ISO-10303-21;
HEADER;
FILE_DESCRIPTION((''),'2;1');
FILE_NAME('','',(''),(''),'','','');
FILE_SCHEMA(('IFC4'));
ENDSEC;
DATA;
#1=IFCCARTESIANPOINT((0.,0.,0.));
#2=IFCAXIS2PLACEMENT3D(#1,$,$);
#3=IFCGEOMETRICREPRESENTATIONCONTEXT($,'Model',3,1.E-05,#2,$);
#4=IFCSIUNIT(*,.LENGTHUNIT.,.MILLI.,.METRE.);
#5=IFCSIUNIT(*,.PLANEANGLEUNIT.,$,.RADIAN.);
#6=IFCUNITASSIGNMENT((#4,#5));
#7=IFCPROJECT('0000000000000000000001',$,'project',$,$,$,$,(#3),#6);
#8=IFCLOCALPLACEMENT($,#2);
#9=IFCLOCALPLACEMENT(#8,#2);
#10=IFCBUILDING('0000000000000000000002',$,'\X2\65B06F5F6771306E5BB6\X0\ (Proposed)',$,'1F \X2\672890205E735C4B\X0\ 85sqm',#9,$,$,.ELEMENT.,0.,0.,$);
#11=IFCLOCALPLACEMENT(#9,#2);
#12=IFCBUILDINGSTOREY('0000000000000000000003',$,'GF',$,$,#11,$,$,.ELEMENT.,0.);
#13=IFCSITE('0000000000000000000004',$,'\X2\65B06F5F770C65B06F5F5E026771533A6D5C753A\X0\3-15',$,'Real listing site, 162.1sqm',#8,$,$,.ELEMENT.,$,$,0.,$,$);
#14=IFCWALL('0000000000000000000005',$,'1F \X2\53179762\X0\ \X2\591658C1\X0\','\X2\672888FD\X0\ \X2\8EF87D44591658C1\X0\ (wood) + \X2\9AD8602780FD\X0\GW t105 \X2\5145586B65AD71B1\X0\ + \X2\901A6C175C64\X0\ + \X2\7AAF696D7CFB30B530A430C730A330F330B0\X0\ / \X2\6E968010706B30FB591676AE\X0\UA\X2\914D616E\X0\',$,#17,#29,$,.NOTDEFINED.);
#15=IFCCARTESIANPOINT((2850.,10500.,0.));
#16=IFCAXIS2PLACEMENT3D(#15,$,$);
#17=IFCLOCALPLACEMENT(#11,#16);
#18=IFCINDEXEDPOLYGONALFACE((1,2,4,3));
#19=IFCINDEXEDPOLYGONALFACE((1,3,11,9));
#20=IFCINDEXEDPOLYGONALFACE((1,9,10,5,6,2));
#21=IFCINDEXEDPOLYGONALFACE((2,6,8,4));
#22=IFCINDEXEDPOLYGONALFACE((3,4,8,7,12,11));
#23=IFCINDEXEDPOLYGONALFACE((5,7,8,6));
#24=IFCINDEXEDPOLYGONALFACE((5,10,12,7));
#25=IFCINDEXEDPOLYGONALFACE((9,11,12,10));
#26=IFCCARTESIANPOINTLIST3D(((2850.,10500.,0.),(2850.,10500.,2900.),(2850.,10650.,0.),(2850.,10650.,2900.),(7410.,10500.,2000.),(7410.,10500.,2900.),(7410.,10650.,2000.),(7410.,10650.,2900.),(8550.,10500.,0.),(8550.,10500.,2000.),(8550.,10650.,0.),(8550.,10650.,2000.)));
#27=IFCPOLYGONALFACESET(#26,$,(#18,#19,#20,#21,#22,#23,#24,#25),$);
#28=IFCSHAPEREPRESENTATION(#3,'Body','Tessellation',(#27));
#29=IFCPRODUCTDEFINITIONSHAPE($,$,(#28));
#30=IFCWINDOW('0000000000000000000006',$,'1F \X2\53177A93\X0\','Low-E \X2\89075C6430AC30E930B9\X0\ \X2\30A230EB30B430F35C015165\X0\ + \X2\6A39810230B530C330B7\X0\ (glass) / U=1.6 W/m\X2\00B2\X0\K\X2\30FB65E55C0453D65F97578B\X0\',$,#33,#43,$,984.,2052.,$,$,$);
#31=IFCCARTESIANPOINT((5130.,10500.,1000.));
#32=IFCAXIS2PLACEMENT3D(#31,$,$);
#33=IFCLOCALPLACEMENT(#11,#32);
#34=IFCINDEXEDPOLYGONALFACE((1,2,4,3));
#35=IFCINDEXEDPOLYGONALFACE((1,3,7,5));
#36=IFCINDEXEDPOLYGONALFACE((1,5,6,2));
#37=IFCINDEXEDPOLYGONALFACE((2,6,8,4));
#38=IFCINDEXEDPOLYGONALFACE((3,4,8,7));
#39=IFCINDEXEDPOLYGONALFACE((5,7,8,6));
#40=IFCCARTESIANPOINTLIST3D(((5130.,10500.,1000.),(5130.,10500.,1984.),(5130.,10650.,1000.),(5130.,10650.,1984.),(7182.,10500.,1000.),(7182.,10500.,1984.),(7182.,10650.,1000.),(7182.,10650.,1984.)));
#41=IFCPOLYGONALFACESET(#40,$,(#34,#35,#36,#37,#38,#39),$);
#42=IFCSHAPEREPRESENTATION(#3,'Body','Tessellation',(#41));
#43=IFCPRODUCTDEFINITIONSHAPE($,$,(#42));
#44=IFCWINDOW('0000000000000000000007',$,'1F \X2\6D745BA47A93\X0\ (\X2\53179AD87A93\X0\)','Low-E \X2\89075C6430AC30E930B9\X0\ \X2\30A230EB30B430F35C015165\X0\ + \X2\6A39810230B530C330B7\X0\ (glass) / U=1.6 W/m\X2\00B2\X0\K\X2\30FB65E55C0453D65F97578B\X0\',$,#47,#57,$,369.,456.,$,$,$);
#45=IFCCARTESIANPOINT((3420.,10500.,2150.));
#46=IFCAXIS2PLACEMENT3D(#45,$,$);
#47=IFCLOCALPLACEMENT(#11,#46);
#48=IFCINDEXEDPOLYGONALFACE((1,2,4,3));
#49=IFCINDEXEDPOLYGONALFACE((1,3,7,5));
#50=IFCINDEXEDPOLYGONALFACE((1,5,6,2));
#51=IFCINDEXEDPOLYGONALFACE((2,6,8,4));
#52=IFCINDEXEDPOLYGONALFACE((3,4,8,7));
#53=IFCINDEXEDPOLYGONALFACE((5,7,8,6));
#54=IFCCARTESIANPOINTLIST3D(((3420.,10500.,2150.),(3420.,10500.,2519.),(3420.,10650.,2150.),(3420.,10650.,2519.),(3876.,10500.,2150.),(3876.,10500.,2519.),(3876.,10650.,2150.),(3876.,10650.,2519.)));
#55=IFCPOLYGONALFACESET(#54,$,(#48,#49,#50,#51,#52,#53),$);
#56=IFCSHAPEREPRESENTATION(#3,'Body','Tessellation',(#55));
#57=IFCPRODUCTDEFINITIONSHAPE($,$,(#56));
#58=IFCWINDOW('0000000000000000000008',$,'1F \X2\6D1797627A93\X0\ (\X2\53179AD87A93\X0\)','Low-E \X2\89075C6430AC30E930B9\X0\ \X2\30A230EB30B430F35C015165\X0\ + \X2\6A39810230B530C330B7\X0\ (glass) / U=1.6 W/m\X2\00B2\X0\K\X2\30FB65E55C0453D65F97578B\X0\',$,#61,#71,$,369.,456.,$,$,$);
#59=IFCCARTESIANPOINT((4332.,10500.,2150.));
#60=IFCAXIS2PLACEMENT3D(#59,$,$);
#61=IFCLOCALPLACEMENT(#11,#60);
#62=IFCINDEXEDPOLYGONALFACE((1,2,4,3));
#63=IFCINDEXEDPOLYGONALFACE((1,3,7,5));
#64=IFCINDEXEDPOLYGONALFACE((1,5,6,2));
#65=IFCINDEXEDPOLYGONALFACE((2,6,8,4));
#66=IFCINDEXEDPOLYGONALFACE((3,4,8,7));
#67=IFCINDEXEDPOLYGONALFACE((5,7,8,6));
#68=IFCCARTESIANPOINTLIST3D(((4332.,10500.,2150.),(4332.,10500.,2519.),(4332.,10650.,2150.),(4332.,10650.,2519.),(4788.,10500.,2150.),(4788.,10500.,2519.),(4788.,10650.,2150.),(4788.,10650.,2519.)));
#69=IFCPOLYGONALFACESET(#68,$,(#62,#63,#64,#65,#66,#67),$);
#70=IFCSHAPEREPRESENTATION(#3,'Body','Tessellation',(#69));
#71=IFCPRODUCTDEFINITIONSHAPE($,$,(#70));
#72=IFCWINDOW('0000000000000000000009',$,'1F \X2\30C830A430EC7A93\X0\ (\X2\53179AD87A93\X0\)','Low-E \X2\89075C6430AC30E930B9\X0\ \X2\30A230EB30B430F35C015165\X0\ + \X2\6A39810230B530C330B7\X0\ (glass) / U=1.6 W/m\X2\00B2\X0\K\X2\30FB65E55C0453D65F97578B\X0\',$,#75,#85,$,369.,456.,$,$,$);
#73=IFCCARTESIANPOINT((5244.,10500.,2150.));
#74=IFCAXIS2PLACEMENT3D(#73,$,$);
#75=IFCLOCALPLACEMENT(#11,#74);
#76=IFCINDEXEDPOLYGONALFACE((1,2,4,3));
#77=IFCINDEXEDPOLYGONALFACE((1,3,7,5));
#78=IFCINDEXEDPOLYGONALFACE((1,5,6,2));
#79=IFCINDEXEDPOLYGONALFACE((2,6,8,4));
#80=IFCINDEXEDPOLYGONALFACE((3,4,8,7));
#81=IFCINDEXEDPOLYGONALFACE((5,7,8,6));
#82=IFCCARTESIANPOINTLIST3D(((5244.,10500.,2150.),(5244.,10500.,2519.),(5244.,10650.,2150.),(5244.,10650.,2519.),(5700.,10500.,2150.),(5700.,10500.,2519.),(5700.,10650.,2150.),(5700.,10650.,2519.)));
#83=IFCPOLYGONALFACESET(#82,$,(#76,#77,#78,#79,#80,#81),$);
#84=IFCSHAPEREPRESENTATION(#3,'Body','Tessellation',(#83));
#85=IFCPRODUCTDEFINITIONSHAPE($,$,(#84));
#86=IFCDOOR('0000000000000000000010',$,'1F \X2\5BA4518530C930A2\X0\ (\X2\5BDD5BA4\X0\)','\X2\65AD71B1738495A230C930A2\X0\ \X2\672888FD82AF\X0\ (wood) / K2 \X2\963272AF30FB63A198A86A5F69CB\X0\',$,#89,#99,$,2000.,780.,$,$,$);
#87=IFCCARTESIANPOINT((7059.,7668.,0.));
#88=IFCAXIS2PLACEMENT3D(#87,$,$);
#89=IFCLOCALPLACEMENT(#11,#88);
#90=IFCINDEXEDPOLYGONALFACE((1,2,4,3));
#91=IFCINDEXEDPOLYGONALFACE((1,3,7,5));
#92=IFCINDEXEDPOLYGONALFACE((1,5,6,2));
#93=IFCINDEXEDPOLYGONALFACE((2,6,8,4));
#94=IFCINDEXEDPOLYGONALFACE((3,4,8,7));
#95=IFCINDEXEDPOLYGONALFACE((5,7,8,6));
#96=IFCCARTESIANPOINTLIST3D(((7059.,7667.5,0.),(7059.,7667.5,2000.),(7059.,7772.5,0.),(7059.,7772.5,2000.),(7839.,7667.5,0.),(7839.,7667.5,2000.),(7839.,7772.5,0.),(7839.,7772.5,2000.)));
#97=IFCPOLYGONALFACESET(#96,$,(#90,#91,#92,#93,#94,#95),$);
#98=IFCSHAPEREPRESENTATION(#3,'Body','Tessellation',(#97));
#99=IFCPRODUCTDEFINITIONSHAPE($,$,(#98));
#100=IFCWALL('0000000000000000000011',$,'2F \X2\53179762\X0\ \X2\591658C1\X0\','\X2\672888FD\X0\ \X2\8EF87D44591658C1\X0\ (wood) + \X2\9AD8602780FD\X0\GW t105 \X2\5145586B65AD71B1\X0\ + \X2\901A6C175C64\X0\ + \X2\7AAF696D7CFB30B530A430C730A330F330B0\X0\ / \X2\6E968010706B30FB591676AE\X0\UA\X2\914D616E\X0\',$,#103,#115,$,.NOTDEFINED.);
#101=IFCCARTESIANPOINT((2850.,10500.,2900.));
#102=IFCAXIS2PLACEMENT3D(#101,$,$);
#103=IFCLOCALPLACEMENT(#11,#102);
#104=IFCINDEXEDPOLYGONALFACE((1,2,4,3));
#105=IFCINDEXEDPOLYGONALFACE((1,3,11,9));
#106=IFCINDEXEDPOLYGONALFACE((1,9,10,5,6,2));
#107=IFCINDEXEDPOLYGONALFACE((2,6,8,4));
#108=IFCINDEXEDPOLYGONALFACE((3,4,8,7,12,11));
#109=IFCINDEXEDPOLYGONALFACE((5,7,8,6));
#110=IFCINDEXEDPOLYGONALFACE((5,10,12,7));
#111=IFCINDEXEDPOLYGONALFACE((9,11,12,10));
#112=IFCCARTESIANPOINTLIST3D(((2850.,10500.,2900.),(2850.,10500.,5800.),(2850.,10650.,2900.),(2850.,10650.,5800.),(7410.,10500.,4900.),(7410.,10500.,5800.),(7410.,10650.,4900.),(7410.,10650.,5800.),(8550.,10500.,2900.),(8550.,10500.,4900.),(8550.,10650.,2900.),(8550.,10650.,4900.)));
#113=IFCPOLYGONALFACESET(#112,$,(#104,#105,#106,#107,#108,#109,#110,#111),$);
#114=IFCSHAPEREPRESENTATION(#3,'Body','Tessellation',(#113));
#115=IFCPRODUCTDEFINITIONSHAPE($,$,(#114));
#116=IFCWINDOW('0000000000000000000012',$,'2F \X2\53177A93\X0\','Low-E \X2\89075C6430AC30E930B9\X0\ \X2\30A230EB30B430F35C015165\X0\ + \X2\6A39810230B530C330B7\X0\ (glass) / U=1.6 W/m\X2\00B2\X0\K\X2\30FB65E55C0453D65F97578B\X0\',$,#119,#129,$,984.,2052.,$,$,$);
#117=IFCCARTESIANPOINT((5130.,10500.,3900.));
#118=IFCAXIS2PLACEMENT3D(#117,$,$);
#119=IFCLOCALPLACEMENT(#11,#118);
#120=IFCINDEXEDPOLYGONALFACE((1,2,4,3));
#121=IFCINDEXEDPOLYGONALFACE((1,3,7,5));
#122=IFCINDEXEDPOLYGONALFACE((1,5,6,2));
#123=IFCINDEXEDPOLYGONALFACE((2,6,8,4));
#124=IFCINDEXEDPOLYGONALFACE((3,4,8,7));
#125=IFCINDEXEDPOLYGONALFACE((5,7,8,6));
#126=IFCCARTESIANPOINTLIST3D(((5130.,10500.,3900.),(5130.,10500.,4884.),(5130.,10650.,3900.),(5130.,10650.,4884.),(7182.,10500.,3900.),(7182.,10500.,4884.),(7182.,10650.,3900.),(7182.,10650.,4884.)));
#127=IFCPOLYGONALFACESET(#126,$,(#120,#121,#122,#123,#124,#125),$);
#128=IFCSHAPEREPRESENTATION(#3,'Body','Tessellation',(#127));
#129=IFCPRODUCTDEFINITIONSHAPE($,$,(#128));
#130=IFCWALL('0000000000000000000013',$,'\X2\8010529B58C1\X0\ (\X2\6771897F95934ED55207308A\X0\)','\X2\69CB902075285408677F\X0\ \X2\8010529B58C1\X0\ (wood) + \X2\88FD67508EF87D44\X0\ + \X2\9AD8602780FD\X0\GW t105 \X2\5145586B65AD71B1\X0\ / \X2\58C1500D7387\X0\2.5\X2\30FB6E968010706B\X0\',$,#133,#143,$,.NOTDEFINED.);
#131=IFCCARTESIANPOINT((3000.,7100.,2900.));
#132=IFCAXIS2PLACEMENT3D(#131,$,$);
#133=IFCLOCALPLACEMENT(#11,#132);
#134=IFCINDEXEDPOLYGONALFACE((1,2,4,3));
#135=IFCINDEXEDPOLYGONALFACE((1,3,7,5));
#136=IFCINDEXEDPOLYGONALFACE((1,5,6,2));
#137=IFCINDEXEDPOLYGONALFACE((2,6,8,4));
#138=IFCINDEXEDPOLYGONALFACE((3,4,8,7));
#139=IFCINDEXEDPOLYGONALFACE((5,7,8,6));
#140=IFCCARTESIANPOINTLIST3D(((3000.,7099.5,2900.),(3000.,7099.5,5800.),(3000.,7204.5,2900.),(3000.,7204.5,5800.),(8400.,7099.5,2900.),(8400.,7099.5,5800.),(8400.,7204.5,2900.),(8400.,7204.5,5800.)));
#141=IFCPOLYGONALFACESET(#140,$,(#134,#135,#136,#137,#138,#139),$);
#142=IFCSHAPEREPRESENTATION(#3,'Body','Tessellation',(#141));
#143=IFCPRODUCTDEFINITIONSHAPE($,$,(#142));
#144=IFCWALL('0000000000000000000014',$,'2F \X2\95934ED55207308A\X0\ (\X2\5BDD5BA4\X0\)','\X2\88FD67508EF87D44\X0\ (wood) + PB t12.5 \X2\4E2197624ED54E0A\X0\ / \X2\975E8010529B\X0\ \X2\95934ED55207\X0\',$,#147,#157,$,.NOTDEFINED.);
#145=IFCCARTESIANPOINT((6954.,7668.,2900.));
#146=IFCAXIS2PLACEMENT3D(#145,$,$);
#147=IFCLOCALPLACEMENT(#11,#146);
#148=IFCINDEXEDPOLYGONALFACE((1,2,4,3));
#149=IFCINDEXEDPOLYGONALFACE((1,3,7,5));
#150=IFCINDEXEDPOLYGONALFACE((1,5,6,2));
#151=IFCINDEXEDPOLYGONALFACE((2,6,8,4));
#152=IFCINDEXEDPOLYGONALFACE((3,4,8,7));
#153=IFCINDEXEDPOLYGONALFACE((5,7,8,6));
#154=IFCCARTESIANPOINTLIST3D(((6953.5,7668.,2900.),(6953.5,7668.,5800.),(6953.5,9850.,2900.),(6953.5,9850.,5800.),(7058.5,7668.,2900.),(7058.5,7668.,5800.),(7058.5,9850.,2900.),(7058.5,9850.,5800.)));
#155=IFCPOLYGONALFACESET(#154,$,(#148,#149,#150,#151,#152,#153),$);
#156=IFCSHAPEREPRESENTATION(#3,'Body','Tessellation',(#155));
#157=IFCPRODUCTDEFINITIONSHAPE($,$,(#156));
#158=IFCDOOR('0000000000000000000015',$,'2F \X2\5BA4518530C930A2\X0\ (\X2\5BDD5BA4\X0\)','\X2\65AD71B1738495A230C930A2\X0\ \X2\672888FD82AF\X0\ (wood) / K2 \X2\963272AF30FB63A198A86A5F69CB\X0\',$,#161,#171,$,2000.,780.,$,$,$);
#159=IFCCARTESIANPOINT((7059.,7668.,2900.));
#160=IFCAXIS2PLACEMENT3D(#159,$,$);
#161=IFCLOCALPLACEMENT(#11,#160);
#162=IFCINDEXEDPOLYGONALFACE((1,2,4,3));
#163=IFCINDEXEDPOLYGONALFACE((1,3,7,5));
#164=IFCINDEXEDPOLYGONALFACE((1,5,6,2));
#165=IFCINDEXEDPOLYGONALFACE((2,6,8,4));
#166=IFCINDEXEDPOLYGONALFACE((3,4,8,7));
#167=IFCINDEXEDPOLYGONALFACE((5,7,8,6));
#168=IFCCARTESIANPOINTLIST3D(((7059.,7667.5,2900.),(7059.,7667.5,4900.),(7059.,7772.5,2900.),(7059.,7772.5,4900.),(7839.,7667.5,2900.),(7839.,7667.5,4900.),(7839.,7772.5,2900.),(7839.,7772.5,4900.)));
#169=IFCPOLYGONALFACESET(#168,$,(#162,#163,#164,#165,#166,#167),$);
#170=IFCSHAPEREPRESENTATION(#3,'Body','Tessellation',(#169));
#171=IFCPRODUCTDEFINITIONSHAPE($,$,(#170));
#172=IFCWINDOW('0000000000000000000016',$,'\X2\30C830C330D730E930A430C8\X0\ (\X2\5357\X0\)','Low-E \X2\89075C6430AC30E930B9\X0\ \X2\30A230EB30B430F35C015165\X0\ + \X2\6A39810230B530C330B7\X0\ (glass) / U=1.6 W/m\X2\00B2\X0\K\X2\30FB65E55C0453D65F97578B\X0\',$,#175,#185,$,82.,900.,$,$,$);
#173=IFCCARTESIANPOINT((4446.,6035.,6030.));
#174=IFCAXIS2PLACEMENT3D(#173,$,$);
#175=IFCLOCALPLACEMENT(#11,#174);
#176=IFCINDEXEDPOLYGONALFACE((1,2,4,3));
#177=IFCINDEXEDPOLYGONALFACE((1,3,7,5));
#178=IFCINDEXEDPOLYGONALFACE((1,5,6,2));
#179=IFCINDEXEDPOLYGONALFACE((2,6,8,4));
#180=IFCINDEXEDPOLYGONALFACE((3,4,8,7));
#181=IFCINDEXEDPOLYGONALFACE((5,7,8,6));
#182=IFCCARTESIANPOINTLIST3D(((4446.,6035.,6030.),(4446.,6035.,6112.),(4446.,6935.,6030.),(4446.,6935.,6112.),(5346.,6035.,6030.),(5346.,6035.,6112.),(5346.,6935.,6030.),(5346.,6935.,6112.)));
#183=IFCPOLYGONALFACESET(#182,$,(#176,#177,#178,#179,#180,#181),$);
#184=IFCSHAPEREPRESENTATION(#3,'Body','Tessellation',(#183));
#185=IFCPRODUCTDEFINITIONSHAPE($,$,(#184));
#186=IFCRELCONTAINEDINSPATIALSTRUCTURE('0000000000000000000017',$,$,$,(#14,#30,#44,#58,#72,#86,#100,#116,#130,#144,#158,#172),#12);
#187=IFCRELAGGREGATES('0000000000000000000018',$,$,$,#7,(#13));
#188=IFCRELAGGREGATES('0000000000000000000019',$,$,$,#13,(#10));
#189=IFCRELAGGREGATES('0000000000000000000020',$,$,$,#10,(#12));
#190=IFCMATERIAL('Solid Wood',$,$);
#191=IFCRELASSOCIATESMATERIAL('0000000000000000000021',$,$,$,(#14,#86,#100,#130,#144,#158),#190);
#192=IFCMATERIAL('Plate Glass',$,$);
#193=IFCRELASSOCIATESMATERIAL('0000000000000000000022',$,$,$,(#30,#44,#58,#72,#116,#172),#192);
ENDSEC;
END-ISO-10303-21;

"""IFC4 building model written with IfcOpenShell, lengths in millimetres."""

from ifc_helpers import new_model, si_unit, frame, frame_2d, origin, place, context, project, spatial, rectangle, extrude, material, element, fill, save


model = new_model("IFC4")

# Units and contexts
model_context = context("Model", 3, precision=1e-05, world=origin())
ifc_project = project(units=[si_unit("LENGTHUNIT", "METRE", prefix="MILLI"), si_unit("PLANEANGLEUNIT", "RADIAN")], contexts=[model_context])

# Site, building, storey
site_placement = place(None, origin())
site = spatial("IfcSite", under=ifc_project, at=site_placement, Name="新潟県新潟市東区浜町3-15", ObjectType="Real listing site, 162.1sqm", CompositionType="ELEMENT", RefElevation=0.0)
building_placement = place(site_placement, origin())
building = spatial("IfcBuilding", under=site, at=building_placement, Name="新潟東の家 (Proposed)", ObjectType="1F 木造平屋 85sqm", CompositionType="ELEMENT", ElevationOfRefHeight=0.0, ElevationOfTerrain=0.0)
storey_placement = place(building_placement, origin())
storey = spatial("IfcBuildingStorey", under=building, at=storey_placement, Name="GF", CompositionType="ELEMENT", Elevation=0.0)

# Wall, openings, windows
ifc_material_1 = material(Name="Solid Wood")
wall_1_placement = place(storey_placement, frame((2850.0, 10500.0, 0.0)))
wall_1 = element("IfcWall", 1, at=wall_1_placement, inside=storey, material=ifc_material_1, Name="1F 北面 外壁", Description="木製 軸組外壁 (wood) + 高性能GW t105 充填断熱 + 通気層 + 窯業系サイディング / 準耐火・外皮UA配慮", PredefinedType="NOTDEFINED", context=model_context, shape_type="SweptSolid", body=[
    extrude(rectangle(XDim=5700.0, YDim=150.0, at=frame_2d((2850.0, 75.0))), frame((2850.0, 10500.0, 0.0)), (0.0, 0.0, 1.0), 2900.0),
])
opening_1_placement = place(storey_placement, frame((5130.0, 10500.0, 1000.0)))
opening_1 = element("IfcOpeningElement", 2, at=opening_1_placement, cuts=wall_1, PredefinedType="NOTDEFINED", context=model_context, shape_type="SweptSolid", body=[
    extrude(rectangle(XDim=2052.0, YDim=150.0, at=frame_2d((1026.0, 75.0))), frame((5130.0, 10500.0, 1000.0)), (0.0, 0.0, 1.0), 984.0),
])
opening_2_placement = place(storey_placement, frame((3420.0, 10500.0, 2150.0)))
opening_2 = element("IfcOpeningElement", 3, at=opening_2_placement, cuts=wall_1, PredefinedType="NOTDEFINED", context=model_context, shape_type="SweptSolid", body=[
    extrude(rectangle(XDim=456.0, YDim=150.0, at=frame_2d((228.0, 75.0))), frame((3420.0, 10500.0, 2150.0)), (0.0, 0.0, 1.0), 369.0),
])
opening_3_placement = place(storey_placement, frame((4332.0, 10500.0, 2150.0)))
opening_3 = element("IfcOpeningElement", 4, at=opening_3_placement, cuts=wall_1, PredefinedType="NOTDEFINED", context=model_context, shape_type="SweptSolid", body=[
    extrude(rectangle(XDim=456.0, YDim=150.0, at=frame_2d((228.0, 75.0))), frame((4332.0, 10500.0, 2150.0)), (0.0, 0.0, 1.0), 369.0),
])
opening_4_placement = place(storey_placement, frame((5244.0, 10500.0, 2150.0)))
opening_4 = element("IfcOpeningElement", 5, at=opening_4_placement, cuts=wall_1, PredefinedType="NOTDEFINED", context=model_context, shape_type="SweptSolid", body=[
    extrude(rectangle(XDim=456.0, YDim=150.0, at=frame_2d((228.0, 75.0))), frame((5244.0, 10500.0, 2150.0)), (0.0, 0.0, 1.0), 369.0),
])
ifc_material_2 = material(Name="Plate Glass")
window_1_placement = place(storey_placement, frame((5130.0, 10500.0, 1000.0)))
window_1 = element("IfcWindow", 6, at=window_1_placement, inside=storey, material=ifc_material_2, Name="1F 北窓", Description="Low-E 複層ガラス アルゴン封入 + 樹脂サッシ (glass) / U=1.6 W/m²K・日射取得型", OverallHeight=984.0, OverallWidth=2052.0, context=model_context, shape_type="SweptSolid", body=[
    extrude(rectangle(XDim=2052.0, YDim=150.0, at=frame_2d((1026.0, 75.0))), frame((5130.0, 10500.0, 1000.0)), (0.0, 0.0, 1.0), 984.0),
])
fill(opening_1, window_1)
window_2_placement = place(storey_placement, frame((3420.0, 10500.0, 2150.0)))
window_2 = element("IfcWindow", 7, at=window_2_placement, inside=storey, material=ifc_material_2, Name="1F 浴室窓 (北高窓)", Description="Low-E 複層ガラス アルゴン封入 + 樹脂サッシ (glass) / U=1.6 W/m²K・日射取得型", OverallHeight=369.0, OverallWidth=456.0, context=model_context, shape_type="SweptSolid", body=[
    extrude(rectangle(XDim=456.0, YDim=150.0, at=frame_2d((228.0, 75.0))), frame((3420.0, 10500.0, 2150.0)), (0.0, 0.0, 1.0), 369.0),
])
fill(opening_2, window_2)
window_3_placement = place(storey_placement, frame((4332.0, 10500.0, 2150.0)))
window_3 = element("IfcWindow", 8, at=window_3_placement, inside=storey, material=ifc_material_2, Name="1F 洗面窓 (北高窓)", Description="Low-E 複層ガラス アルゴン封入 + 樹脂サッシ (glass) / U=1.6 W/m²K・日射取得型", OverallHeight=369.0, OverallWidth=456.0, context=model_context, shape_type="SweptSolid", body=[
    extrude(rectangle(XDim=456.0, YDim=150.0, at=frame_2d((228.0, 75.0))), frame((4332.0, 10500.0, 2150.0)), (0.0, 0.0, 1.0), 369.0),
])
fill(opening_3, window_3)
window_4_placement = place(storey_placement, frame((5244.0, 10500.0, 2150.0)))
window_4 = element("IfcWindow", 9, at=window_4_placement, inside=storey, material=ifc_material_2, Name="1F トイレ窓 (北高窓)", Description="Low-E 複層ガラス アルゴン封入 + 樹脂サッシ (glass) / U=1.6 W/m²K・日射取得型", OverallHeight=369.0, OverallWidth=456.0, context=model_context, shape_type="SweptSolid", body=[
    extrude(rectangle(XDim=456.0, YDim=150.0, at=frame_2d((228.0, 75.0))), frame((5244.0, 10500.0, 2150.0)), (0.0, 0.0, 1.0), 369.0),
])
fill(opening_4, window_4)

# Door
door_1_placement = place(storey_placement, frame((7059.0, 7668.0, 0.0)))
element("IfcDoor", 10, at=door_1_placement, inside=storey, material=ifc_material_1, Name="1F 室内ドア (寝室)", Description="断熱玄関ドア 木製芯 (wood) / K2 防犯・採風機構", OverallHeight=2000.0, OverallWidth=780.0, context=model_context, shape_type="SweptSolid", body=[
    extrude(rectangle(XDim=780.0, YDim=105.0, at=frame_2d((390.0, 52.0))), frame((7059.0, 7668.0, 0.0)), (0.0, 0.0, 1.0), 2000.0),
])

# Wall, opening, window
wall_2_placement = place(storey_placement, frame((2850.0, 10500.0, 2900.0)))
wall_2 = element("IfcWall", 11, at=wall_2_placement, inside=storey, material=ifc_material_1, Name="2F 北面 外壁", Description="木製 軸組外壁 (wood) + 高性能GW t105 充填断熱 + 通気層 + 窯業系サイディング / 準耐火・外皮UA配慮", PredefinedType="NOTDEFINED", context=model_context, shape_type="SweptSolid", body=[
    extrude(rectangle(XDim=5700.0, YDim=150.0, at=frame_2d((2850.0, 75.0))), frame((2850.0, 10500.0, 2900.0)), (0.0, 0.0, 1.0), 2900.0),
])
opening_5_placement = place(storey_placement, frame((5130.0, 10500.0, 3900.0)))
opening_5 = element("IfcOpeningElement", 12, at=opening_5_placement, cuts=wall_2, PredefinedType="NOTDEFINED", context=model_context, shape_type="SweptSolid", body=[
    extrude(rectangle(XDim=2052.0, YDim=150.0, at=frame_2d((1026.0, 75.0))), frame((5130.0, 10500.0, 3900.0)), (0.0, 0.0, 1.0), 984.0),
])
window_5_placement = place(storey_placement, frame((5130.0, 10500.0, 3900.0)))
window_5 = element("IfcWindow", 13, at=window_5_placement, inside=storey, material=ifc_material_2, Name="2F 北窓", Description="Low-E 複層ガラス アルゴン封入 + 樹脂サッシ (glass) / U=1.6 W/m²K・日射取得型", OverallHeight=984.0, OverallWidth=2052.0, context=model_context, shape_type="SweptSolid", body=[
    extrude(rectangle(XDim=2052.0, YDim=150.0, at=frame_2d((1026.0, 75.0))), frame((5130.0, 10500.0, 3900.0)), (0.0, 0.0, 1.0), 984.0),
])
fill(opening_5, window_5)

# Walls
wall_3_placement = place(storey_placement, frame((3000.0, 7100.0, 2900.0)))
element("IfcWall", 14, at=wall_3_placement, inside=storey, material=ifc_material_1, Name="耐力壁 (東西間仕切り)", Description="構造用合板 耐力壁 (wood) + 製材軸組 + 高性能GW t105 充填断熱 / 壁倍率2.5・準耐火", PredefinedType="NOTDEFINED", context=model_context, shape_type="SweptSolid", body=[
    extrude(rectangle(XDim=5400.0, YDim=105.0, at=frame_2d((2700.0, 52.0))), frame((3000.0, 7100.0, 2900.0)), (0.0, 0.0, 1.0), 2900.0),
])
wall_4_placement = place(storey_placement, frame((6954.0, 7668.0, 2900.0)))
element("IfcWall", 15, at=wall_4_placement, inside=storey, material=ifc_material_1, Name="2F 間仕切り (寝室)", Description="製材軸組 (wood) + PB t12.5 両面仕上 / 非耐力 間仕切", PredefinedType="NOTDEFINED", context=model_context, shape_type="SweptSolid", body=[
    extrude(rectangle(XDim=105.0, YDim=2182.0, at=frame_2d((52.0, 1091.0))), frame((6954.0, 7668.0, 2900.0)), (0.0, 0.0, 1.0), 2900.0),
])

# Door
door_2_placement = place(storey_placement, frame((7059.0, 7668.0, 2900.0)))
element("IfcDoor", 16, at=door_2_placement, inside=storey, material=ifc_material_1, Name="2F 室内ドア (寝室)", Description="断熱玄関ドア 木製芯 (wood) / K2 防犯・採風機構", OverallHeight=2000.0, OverallWidth=780.0, context=model_context, shape_type="SweptSolid", body=[
    extrude(rectangle(XDim=780.0, YDim=105.0, at=frame_2d((390.0, 52.0))), frame((7059.0, 7668.0, 2900.0)), (0.0, 0.0, 1.0), 2000.0),
])

# Window
window_6_placement = place(storey_placement, frame((4446.0, 6035.0, 6030.0)))
element("IfcWindow", 17, at=window_6_placement, inside=storey, material=ifc_material_2, Name="トップライト (南)", Description="Low-E 複層ガラス アルゴン封入 + 樹脂サッシ (glass) / U=1.6 W/m²K・日射取得型", OverallHeight=82.0, OverallWidth=900.0, context=model_context, shape_type="SweptSolid", body=[
    extrude(rectangle(XDim=900.0, YDim=900.0, at=frame_2d((450.0, 450.0))), frame((4446.0, 6035.0, 6030.0)), (0.0, 0.0, 1.0), 82.0),
])

save(model, "model.ifc")
